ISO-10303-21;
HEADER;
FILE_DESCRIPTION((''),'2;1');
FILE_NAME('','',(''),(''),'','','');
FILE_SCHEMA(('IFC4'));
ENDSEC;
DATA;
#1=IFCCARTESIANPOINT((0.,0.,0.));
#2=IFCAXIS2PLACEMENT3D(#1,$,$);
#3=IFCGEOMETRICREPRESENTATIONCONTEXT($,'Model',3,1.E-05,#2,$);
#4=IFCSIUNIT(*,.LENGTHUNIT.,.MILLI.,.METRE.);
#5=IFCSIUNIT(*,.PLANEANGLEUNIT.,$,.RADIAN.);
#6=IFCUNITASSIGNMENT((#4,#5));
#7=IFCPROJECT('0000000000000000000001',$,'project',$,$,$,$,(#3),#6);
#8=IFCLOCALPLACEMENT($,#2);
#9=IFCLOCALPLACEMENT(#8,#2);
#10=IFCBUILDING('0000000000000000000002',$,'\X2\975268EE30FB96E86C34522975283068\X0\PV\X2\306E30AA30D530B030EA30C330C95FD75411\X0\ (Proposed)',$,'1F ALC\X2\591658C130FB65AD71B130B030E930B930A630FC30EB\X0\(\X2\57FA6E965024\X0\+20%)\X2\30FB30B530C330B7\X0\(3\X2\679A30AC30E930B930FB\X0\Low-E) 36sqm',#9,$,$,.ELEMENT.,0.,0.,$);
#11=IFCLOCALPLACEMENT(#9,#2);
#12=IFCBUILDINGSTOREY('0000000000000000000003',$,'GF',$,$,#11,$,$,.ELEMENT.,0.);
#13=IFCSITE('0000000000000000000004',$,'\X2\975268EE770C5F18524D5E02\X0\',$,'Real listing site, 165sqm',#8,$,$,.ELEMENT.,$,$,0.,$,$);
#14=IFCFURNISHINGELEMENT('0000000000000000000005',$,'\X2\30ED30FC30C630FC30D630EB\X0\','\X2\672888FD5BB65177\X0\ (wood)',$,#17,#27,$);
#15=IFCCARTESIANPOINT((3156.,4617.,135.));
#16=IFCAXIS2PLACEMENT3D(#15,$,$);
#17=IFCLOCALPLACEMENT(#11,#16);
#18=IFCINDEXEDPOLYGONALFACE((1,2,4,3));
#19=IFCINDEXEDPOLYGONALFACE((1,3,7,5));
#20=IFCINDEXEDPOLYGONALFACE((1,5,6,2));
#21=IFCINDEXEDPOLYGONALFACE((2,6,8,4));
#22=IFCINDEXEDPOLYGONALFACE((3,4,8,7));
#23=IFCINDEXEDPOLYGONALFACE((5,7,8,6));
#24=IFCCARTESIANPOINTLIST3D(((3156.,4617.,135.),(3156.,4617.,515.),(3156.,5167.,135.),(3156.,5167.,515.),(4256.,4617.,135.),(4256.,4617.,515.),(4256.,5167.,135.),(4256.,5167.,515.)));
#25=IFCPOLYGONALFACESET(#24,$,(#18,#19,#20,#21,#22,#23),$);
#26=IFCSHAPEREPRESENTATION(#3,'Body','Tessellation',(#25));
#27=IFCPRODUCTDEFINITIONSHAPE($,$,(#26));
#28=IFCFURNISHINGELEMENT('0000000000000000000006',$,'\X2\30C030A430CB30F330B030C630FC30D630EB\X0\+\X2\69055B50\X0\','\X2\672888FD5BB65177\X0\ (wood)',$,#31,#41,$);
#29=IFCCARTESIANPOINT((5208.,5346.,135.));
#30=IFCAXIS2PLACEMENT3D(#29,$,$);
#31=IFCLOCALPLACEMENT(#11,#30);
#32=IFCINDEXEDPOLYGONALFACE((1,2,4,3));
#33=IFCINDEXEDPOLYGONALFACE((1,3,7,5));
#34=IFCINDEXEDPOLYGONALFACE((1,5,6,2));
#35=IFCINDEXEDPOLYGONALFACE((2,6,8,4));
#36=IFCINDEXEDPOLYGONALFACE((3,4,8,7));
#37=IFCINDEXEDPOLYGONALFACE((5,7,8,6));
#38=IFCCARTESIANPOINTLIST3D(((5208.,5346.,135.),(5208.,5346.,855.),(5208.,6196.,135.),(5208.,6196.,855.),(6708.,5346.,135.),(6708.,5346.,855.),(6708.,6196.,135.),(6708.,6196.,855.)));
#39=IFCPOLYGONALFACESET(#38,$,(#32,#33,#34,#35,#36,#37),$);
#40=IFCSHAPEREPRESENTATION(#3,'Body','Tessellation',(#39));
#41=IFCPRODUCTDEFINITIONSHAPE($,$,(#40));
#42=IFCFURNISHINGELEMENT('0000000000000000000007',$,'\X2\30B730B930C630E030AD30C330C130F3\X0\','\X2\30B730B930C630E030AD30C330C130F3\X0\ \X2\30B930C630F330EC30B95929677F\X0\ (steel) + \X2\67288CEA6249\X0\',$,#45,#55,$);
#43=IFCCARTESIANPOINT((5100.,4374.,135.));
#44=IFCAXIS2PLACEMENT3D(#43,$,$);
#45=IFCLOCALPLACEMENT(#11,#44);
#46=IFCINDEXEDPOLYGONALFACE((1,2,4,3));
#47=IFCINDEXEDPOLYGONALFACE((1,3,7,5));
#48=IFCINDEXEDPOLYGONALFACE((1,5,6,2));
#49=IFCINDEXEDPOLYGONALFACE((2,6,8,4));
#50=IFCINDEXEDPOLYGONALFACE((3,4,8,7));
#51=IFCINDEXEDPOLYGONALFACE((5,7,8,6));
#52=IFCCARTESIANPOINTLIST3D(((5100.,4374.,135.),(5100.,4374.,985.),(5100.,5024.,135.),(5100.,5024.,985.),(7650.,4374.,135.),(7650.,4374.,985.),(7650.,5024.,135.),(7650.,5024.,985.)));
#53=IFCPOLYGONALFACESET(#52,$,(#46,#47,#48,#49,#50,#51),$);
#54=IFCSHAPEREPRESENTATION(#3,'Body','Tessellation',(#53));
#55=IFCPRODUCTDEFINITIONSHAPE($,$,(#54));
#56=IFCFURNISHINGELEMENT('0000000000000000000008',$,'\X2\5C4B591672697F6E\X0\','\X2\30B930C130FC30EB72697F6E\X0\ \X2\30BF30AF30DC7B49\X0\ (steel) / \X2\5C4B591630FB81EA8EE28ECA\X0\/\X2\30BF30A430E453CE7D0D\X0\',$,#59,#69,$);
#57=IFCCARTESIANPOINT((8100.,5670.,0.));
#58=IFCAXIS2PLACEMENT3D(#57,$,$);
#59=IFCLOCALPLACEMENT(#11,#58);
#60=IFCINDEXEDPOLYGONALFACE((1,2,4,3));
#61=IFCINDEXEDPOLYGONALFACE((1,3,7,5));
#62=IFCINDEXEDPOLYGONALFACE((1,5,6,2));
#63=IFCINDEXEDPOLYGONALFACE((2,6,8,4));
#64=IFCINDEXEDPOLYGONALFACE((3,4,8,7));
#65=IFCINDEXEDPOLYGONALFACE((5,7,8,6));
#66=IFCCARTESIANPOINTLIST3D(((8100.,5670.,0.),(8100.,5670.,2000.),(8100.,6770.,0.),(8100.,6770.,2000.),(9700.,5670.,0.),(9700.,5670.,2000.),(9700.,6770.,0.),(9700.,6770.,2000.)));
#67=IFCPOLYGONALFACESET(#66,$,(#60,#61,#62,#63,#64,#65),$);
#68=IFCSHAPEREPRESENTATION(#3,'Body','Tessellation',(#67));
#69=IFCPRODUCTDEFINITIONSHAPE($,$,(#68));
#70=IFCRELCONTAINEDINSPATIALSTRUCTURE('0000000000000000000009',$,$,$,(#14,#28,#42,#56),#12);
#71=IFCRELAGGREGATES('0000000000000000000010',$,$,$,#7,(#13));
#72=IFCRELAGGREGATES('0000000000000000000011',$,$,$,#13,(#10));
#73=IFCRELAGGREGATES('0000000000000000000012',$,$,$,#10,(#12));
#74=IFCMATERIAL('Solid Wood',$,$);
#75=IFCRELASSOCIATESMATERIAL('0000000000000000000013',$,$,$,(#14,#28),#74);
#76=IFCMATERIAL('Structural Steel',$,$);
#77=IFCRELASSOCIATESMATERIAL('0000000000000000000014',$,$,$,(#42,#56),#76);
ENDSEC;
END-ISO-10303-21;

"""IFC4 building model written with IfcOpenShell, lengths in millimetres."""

from ifc_helpers import new_model, si_unit, frame, frame_2d, origin, place, context, project, spatial, rectangle, extrude, material, element, save


model = new_model("IFC4")

# Units and contexts
model_context = context("Model", 3, precision=1e-05, world=origin())
ifc_project = project(units=[si_unit("LENGTHUNIT", "METRE", prefix="MILLI"), si_unit("PLANEANGLEUNIT", "RADIAN")], contexts=[model_context])

# Site, building, storey
site_placement = place(None, origin())
site = spatial("IfcSite", under=ifc_project, at=site_placement, Name="青森県弘前市", ObjectType="Real listing site, 165sqm", CompositionType="ELEMENT", RefElevation=0.0)
building_placement = place(site_placement, origin())
building = spatial("IfcBuilding", under=site, at=building_placement, Name="青森・雨水利用とPVのオフグリッド志向 (Proposed)", ObjectType="1F ALC外壁・断熱グラスウール(基準値+20%)・サッシ(3枚ガラス・Low-E) 36sqm", CompositionType="ELEMENT", ElevationOfRefHeight=0.0, ElevationOfTerrain=0.0)
storey_placement = place(building_placement, origin())
storey = spatial("IfcBuildingStorey", under=building, at=storey_placement, Name="GF", CompositionType="ELEMENT", Elevation=0.0)

# Shared definitions
ifc_material_1 = material(Name="Solid Wood")

# Shared definitions
ifc_material_2 = material(Name="Structural Steel")

# Furnishing elements
furnishing_1_placement = place(storey_placement, frame((3156.0, 4617.0, 135.0)))
element("IfcFurnishingElement", 1, at=furnishing_1_placement, inside=storey, material=ifc_material_1, Name="ローテーブル", Description="木製家具 (wood)", context=model_context, shape_type="SweptSolid", body=[
    extrude(rectangle(XDim=1100.0, YDim=550.0, at=frame_2d((550.0, 275.0))), frame((3156.0, 4617.0, 135.0)), (0.0, 0.0, 1.0), 380.0),
])
furnishing_2_placement = place(storey_placement, frame((5208.0, 5346.0, 135.0)))
element("IfcFurnishingElement", 2, at=furnishing_2_placement, inside=storey, material=ifc_material_1, Name="ダイニングテーブル+椅子", Description="木製家具 (wood)", context=model_context, shape_type="SweptSolid", body=[
    extrude(rectangle(XDim=1500.0, YDim=850.0, at=frame_2d((750.0, 425.0))), frame((5208.0, 5346.0, 135.0)), (0.0, 0.0, 1.0), 720.0),
])
furnishing_3_placement = place(storey_placement, frame((5100.0, 4374.0, 135.0)))
element("IfcFurnishingElement", 3, at=furnishing_3_placement, inside=storey, material=ifc_material_2, Name="システムキッチン", Description="システムキッチン ステンレス天板 (steel) + 木質扉", context=model_context, shape_type="SweptSolid", body=[
    extrude(rectangle(XDim=2550.0, YDim=650.0, at=frame_2d((1275.0, 325.0))), frame((5100.0, 4374.0, 135.0)), (0.0, 0.0, 1.0), 850.0),
])
furnishing_4_placement = place(storey_placement, frame((8100.0, 5670.0, 0.0)))
element("IfcFurnishingElement", 4, at=furnishing_4_placement, inside=storey, material=ifc_material_2, Name="屋外物置", Description="スチール物置 タクボ等 (steel) / 屋外・自転車/タイヤ収納", context=model_context, shape_type="SweptSolid", body=[
    extrude(rectangle(XDim=1600.0, YDim=1100.0, at=frame_2d((800.0, 550.0))), frame((8100.0, 5670.0, 0.0)), (0.0, 0.0, 1.0), 2000.0),
])

save(model, "model.ifc")
